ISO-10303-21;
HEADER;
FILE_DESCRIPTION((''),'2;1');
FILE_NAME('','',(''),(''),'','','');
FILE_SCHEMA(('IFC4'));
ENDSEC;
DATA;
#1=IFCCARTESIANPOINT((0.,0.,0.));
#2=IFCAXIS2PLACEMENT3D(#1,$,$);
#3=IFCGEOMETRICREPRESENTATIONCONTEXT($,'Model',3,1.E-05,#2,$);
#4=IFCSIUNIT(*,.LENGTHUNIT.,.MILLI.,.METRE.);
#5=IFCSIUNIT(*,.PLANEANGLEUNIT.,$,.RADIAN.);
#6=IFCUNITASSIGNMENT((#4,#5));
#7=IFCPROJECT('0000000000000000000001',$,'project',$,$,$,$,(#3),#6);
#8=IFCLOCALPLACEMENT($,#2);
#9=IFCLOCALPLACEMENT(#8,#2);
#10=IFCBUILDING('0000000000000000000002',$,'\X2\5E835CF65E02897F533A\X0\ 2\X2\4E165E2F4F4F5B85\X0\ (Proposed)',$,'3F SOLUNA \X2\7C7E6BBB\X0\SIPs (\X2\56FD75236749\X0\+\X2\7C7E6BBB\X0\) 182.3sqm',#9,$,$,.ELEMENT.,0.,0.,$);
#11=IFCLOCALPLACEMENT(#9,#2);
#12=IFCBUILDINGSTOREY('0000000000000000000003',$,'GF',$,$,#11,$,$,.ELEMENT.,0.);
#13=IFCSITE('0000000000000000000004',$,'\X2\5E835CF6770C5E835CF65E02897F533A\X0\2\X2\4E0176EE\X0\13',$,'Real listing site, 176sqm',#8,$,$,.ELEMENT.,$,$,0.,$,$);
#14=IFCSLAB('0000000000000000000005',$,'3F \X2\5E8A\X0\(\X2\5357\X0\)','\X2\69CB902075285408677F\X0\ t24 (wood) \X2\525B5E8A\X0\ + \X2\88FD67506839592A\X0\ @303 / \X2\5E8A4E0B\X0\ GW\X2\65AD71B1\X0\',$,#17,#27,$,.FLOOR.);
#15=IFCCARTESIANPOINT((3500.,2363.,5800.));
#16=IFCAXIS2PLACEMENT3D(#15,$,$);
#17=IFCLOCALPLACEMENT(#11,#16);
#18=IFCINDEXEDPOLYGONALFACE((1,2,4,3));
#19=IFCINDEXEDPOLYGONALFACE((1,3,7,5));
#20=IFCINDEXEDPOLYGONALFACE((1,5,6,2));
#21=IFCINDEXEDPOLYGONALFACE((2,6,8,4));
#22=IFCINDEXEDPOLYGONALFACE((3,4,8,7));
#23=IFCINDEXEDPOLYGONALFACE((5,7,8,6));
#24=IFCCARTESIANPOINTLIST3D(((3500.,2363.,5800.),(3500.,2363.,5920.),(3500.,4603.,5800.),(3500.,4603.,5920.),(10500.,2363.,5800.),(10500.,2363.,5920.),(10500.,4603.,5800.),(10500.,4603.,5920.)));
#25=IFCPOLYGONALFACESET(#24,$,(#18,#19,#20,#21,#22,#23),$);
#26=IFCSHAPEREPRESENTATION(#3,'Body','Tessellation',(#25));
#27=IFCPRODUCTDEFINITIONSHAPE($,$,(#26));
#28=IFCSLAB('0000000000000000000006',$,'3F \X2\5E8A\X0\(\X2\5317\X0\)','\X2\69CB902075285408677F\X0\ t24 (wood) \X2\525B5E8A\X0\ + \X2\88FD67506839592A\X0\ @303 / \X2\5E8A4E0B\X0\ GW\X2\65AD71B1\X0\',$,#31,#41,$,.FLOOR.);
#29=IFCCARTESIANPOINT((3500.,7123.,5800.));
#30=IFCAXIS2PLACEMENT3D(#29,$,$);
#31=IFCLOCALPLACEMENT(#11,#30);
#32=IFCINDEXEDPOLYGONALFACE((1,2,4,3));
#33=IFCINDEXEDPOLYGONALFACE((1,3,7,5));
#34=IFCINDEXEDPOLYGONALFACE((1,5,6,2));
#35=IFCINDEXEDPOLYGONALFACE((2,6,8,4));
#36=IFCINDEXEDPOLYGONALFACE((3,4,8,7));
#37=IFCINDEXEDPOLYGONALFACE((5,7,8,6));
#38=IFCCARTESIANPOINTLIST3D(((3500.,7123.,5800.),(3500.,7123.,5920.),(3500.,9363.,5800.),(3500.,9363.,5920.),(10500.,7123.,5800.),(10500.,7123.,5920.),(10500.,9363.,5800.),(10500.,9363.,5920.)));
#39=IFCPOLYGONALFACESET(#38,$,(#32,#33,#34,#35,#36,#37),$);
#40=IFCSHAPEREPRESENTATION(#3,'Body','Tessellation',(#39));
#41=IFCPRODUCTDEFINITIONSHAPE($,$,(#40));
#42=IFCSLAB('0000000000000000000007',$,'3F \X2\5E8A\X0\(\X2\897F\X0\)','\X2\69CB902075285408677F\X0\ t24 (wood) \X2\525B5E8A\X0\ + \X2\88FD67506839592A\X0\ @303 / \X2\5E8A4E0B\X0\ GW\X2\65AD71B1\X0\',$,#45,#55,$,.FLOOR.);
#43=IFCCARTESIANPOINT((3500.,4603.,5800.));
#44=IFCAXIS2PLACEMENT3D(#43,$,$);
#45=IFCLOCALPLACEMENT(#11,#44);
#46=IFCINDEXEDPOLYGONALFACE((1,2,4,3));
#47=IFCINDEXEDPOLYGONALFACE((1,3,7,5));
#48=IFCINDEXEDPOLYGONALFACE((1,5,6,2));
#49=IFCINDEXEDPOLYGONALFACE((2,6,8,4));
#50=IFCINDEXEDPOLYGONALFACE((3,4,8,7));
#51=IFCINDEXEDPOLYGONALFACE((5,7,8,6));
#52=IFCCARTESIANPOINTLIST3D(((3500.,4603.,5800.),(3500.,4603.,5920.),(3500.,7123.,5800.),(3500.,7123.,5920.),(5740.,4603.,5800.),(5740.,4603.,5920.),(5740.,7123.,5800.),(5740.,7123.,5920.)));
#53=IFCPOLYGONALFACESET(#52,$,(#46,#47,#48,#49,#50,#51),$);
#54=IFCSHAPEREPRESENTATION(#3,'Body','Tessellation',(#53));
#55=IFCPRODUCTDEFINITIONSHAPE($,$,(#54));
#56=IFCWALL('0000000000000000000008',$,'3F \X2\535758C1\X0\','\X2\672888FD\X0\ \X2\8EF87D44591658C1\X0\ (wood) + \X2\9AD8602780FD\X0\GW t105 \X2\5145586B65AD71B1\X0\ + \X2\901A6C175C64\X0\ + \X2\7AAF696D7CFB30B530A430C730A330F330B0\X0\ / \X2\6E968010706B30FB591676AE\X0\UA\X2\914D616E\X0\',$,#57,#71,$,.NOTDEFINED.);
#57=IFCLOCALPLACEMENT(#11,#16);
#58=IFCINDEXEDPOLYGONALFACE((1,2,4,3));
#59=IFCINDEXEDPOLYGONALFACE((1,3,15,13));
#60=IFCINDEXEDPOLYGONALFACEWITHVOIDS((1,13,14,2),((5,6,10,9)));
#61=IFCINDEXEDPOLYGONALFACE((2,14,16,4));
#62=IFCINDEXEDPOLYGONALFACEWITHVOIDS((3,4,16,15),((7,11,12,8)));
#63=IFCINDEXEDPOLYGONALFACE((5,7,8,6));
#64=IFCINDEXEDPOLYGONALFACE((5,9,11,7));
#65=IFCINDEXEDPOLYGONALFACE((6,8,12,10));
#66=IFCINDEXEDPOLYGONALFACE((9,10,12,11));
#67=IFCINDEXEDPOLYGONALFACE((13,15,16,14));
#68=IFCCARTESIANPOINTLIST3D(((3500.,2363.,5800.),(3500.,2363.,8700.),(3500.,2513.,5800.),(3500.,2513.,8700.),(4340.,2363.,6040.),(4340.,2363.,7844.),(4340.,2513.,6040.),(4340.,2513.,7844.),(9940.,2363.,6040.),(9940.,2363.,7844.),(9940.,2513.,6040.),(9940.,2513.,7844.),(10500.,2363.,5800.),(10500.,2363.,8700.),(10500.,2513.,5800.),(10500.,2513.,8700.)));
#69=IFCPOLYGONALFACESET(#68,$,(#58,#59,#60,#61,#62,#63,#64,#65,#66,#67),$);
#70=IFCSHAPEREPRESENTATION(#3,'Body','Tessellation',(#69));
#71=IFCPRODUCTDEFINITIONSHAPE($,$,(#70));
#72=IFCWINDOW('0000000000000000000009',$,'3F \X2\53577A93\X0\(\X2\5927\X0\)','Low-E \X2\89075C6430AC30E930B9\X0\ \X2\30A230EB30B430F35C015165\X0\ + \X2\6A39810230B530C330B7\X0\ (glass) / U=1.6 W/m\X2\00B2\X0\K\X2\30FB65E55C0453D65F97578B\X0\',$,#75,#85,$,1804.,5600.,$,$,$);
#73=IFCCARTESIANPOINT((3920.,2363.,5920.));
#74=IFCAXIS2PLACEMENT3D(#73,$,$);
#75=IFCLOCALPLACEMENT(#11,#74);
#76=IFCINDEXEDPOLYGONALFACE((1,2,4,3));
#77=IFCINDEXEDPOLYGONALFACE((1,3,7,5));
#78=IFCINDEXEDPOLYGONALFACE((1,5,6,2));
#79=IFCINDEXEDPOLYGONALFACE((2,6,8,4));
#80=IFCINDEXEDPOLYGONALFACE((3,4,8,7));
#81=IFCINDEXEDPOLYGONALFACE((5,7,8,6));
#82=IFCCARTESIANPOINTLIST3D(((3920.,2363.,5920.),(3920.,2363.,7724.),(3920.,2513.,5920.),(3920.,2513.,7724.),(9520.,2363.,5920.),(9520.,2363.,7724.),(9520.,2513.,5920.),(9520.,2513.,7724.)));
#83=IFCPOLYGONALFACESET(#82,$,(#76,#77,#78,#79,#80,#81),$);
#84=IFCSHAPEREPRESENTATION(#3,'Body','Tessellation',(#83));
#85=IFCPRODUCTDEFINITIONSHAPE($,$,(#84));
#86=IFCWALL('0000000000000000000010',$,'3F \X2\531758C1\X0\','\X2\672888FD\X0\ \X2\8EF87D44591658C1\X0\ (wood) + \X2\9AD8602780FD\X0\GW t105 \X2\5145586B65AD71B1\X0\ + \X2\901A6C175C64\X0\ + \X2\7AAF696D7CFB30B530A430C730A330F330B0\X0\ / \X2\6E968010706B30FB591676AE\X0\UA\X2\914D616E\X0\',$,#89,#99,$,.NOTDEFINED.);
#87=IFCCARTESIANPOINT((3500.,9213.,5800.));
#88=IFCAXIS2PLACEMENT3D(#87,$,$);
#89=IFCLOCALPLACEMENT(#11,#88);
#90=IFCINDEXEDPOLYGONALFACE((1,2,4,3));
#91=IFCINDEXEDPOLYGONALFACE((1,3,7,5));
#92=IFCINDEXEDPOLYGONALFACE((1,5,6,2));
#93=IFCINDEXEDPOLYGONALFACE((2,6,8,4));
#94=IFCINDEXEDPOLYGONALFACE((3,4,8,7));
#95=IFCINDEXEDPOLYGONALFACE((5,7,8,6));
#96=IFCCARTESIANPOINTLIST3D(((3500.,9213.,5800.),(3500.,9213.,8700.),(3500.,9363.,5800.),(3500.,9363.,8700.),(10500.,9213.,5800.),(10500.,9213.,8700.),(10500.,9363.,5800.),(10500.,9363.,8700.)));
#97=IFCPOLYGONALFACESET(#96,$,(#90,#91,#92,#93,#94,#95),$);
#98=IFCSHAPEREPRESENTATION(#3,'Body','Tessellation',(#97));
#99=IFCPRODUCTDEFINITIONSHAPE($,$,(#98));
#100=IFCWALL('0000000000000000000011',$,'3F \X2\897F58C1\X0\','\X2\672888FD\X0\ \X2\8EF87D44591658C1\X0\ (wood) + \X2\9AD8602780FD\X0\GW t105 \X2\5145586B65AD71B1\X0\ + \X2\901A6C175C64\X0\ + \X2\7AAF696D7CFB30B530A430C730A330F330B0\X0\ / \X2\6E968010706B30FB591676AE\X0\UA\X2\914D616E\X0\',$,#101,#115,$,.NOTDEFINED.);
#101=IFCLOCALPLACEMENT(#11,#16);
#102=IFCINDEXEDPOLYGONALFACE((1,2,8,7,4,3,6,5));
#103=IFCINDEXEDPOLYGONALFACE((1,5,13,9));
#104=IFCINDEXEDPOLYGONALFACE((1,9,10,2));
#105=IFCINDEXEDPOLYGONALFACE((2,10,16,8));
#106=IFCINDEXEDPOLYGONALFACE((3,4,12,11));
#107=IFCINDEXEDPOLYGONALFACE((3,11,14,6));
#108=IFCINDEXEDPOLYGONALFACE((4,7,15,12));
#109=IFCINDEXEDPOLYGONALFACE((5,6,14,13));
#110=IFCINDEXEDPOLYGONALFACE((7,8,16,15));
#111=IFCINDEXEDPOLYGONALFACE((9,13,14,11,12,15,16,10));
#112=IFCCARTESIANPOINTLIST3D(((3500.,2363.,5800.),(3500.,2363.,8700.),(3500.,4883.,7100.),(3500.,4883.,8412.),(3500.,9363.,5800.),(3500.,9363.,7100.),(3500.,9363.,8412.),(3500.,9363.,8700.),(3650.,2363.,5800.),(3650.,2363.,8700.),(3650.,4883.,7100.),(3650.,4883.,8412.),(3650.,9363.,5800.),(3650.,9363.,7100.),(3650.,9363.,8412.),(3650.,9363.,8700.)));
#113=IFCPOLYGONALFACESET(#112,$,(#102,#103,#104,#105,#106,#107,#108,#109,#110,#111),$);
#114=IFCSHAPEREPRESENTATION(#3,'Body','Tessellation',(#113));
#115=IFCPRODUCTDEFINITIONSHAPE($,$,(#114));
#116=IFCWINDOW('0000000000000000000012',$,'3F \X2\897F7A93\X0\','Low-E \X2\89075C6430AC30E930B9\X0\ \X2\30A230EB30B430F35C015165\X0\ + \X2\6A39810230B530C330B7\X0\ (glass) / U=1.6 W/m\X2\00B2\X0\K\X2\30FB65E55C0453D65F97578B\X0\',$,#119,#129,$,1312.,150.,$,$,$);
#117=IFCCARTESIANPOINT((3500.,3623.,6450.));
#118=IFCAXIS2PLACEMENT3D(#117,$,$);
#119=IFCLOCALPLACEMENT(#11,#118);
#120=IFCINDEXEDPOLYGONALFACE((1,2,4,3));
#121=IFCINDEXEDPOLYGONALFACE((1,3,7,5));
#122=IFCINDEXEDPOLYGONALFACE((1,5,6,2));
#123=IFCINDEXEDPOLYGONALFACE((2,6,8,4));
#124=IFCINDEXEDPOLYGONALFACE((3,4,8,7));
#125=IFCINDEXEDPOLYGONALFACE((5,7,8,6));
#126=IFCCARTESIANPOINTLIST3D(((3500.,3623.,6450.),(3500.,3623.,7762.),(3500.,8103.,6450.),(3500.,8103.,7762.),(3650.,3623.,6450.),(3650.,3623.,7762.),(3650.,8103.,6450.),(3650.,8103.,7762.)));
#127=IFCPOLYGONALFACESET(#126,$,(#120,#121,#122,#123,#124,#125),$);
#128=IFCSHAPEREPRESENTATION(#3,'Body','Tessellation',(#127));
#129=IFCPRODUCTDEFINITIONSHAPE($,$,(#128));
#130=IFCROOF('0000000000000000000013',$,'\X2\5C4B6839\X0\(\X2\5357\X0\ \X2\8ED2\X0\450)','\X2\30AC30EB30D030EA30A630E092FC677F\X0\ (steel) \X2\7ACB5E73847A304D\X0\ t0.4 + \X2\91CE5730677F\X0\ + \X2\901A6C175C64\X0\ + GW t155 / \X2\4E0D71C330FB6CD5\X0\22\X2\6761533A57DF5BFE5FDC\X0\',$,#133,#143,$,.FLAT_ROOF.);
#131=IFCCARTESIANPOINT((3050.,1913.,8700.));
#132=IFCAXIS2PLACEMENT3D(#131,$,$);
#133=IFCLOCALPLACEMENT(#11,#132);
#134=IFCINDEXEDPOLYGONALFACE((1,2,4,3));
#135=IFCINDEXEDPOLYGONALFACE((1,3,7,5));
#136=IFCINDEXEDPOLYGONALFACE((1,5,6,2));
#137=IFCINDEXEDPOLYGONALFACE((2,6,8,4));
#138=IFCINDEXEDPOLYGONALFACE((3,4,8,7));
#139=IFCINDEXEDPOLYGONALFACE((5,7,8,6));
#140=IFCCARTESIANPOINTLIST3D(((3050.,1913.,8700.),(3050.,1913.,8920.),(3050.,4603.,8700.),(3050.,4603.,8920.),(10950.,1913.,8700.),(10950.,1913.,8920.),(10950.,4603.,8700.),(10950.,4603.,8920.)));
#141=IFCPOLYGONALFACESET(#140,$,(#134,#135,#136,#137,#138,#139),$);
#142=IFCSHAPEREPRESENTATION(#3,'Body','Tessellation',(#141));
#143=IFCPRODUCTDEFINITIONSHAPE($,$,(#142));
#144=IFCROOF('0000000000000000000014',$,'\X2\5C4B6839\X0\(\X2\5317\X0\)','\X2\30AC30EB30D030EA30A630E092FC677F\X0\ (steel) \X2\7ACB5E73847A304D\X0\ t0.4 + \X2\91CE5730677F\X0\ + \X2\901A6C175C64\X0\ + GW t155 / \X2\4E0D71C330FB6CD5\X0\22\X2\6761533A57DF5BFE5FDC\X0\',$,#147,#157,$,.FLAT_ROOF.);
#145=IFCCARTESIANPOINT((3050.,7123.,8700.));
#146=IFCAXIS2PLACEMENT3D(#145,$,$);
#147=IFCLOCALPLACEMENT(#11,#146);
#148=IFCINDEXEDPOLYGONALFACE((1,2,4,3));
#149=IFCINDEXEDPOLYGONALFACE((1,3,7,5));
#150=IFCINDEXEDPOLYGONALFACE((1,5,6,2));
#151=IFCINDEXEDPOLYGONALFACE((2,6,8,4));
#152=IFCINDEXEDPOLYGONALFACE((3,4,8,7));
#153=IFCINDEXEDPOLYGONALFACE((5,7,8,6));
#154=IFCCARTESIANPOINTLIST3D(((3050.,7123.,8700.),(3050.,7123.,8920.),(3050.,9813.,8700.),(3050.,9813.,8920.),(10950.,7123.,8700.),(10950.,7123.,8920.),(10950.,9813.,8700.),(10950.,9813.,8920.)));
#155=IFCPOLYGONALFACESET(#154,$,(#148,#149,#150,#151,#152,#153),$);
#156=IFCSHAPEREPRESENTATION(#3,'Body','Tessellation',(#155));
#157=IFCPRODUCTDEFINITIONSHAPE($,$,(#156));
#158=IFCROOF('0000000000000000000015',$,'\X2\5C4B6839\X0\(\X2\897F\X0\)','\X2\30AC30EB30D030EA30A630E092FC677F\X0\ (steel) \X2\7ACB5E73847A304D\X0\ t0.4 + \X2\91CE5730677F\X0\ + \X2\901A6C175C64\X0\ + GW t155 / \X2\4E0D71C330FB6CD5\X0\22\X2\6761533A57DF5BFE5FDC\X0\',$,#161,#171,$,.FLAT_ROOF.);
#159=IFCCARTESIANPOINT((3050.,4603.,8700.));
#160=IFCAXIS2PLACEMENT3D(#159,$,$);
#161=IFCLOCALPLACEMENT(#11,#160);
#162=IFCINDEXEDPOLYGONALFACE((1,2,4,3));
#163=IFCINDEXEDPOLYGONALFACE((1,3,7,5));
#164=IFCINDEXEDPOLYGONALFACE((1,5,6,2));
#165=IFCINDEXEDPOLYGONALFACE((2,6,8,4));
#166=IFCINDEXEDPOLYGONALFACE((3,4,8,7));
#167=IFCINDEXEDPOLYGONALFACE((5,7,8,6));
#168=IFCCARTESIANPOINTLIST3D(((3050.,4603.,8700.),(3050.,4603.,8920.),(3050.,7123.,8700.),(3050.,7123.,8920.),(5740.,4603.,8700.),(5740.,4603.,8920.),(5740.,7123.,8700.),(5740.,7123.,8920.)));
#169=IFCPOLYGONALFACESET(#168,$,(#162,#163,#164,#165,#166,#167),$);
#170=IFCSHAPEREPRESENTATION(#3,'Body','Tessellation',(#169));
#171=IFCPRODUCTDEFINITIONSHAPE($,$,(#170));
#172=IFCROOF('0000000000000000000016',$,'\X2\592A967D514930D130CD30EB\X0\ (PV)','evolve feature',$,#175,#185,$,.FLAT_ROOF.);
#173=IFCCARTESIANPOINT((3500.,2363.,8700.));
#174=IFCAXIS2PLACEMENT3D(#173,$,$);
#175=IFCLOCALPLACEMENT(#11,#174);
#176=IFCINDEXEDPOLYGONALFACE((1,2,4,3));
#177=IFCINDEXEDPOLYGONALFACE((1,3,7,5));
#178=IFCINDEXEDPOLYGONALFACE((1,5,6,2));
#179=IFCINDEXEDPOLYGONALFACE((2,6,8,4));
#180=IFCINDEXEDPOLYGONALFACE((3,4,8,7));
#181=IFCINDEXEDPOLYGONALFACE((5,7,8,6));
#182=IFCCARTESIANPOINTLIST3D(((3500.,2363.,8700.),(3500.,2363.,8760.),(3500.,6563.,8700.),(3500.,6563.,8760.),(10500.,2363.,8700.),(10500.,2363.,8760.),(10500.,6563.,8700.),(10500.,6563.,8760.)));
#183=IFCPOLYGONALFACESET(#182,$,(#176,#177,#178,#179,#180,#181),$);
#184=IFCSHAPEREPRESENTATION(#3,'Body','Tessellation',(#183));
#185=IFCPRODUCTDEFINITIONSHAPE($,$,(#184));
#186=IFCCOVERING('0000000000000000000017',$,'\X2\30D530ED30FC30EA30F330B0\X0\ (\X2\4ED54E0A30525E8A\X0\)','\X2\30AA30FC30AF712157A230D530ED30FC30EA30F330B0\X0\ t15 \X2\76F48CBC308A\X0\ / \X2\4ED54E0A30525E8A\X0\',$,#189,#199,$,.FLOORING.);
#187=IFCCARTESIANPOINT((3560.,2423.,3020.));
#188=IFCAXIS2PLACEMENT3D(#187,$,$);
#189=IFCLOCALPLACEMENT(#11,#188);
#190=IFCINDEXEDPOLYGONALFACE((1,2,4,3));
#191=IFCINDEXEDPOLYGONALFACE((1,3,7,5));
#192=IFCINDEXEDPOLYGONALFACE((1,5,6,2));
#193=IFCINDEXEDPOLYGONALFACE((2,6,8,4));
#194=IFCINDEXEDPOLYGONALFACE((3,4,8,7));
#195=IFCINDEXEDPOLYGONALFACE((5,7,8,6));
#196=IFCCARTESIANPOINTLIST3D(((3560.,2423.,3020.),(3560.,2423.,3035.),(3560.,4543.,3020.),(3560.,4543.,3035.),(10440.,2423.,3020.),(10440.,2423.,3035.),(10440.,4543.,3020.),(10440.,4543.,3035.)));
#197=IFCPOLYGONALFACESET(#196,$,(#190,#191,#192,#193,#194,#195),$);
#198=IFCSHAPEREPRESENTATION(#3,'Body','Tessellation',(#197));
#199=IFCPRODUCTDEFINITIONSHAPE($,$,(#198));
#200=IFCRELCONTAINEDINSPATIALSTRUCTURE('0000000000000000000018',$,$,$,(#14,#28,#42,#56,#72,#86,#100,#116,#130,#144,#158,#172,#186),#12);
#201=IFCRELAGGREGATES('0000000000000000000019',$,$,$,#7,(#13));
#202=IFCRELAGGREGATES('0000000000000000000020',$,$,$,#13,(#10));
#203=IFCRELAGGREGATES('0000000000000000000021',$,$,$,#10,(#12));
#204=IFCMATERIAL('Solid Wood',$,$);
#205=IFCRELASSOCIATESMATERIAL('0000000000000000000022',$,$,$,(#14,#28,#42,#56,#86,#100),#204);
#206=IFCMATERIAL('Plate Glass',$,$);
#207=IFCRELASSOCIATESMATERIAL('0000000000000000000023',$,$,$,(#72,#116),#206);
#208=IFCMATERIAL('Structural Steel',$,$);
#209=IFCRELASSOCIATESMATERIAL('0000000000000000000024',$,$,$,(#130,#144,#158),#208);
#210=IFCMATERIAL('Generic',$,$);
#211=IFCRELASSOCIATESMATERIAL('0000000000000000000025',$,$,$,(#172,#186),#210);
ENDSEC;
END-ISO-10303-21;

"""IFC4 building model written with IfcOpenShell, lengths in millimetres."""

from ifc_helpers import new_model, si_unit, frame, frame_2d, origin, place, context, project, spatial, rectangle, extrude, material, element, fill, save


model = new_model("IFC4")

# Units and contexts
model_context = context("Model", 3, precision=1e-05, world=origin())
ifc_project = project(units=[si_unit("LENGTHUNIT", "METRE", prefix="MILLI"), si_unit("PLANEANGLEUNIT", "RADIAN")], contexts=[model_context])

# Site, building, storey
site_placement = place(None, origin())
site = spatial("IfcSite", under=ifc_project, at=site_placement, Name="広島県広島市西区2丁目13", ObjectType="Real listing site, 176sqm", CompositionType="ELEMENT", RefElevation=0.0)
building_placement = place(site_placement, origin())
building = spatial("IfcBuilding", under=site, at=building_placement, Name="広島市西区 2世帯住宅 (Proposed)", ObjectType="3F SOLUNA 籾殻SIPs (国産杉+籾殻) 182.3sqm", CompositionType="ELEMENT", ElevationOfRefHeight=0.0, ElevationOfTerrain=0.0)
storey_placement = place(building_placement, origin())
storey = spatial("IfcBuildingStorey", under=building, at=storey_placement, Name="GF", CompositionType="ELEMENT", Elevation=0.0)

# Slabs
ifc_material_1 = material(Name="Solid Wood")
slab_1_placement = place(storey_placement, frame((3500.0, 2363.0, 5800.0)))
element("IfcSlab", 1, at=slab_1_placement, inside=storey, material=ifc_material_1, Name="3F 床(南)", Description="構造用合板 t24 (wood) 剛床 + 製材根太 @303 / 床下 GW断熱", PredefinedType="FLOOR", context=model_context, shape_type="SweptSolid", body=[
    extrude(rectangle(XDim=7000.0, YDim=2240.0, at=frame_2d((3500.0, 1120.0))), frame((3500.0, 2363.0, 5800.0)), (0.0, 0.0, 1.0), 120.0),
])
slab_2_placement = place(storey_placement, frame((3500.0, 7123.0, 5800.0)))
element("IfcSlab", 2, at=slab_2_placement, inside=storey, material=ifc_material_1, Name="3F 床(北)", Description="構造用合板 t24 (wood) 剛床 + 製材根太 @303 / 床下 GW断熱", PredefinedType="FLOOR", context=model_context, shape_type="SweptSolid", body=[
    extrude(rectangle(XDim=7000.0, YDim=2240.0, at=frame_2d((3500.0, 1120.0))), frame((3500.0, 7123.0, 5800.0)), (0.0, 0.0, 1.0), 120.0),
])
slab_3_placement = place(storey_placement, frame((3500.0, 4603.0, 5800.0)))
element("IfcSlab", 3, at=slab_3_placement, inside=storey, material=ifc_material_1, Name="3F 床(西)", Description="構造用合板 t24 (wood) 剛床 + 製材根太 @303 / 床下 GW断熱", PredefinedType="FLOOR", context=model_context, shape_type="SweptSolid", body=[
    extrude(rectangle(XDim=2240.0, YDim=2520.0, at=frame_2d((1120.0, 1260.0))), frame((3500.0, 4603.0, 5800.0)), (0.0, 0.0, 1.0), 120.0),
])

# Wall, opening, window
wall_1_placement = place(storey_placement, frame((3500.0, 2363.0, 5800.0)))
wall_1 = element("IfcWall", 4, at=wall_1_placement, inside=storey, material=ifc_material_1, Name="3F 南壁", Description="木製 軸組外壁 (wood) + 高性能GW t105 充填断熱 + 通気層 + 窯業系サイディング / 準耐火・外皮UA配慮", PredefinedType="NOTDEFINED", context=model_context, shape_type="SweptSolid", body=[
    extrude(rectangle(XDim=7000.0, YDim=150.0, at=frame_2d((3500.0, 75.0))), frame((3500.0, 2363.0, 5800.0)), (0.0, 0.0, 1.0), 2900.0),
])
opening_1_placement = place(storey_placement, frame((3920.0, 2363.0, 5920.0)))
opening_1 = element("IfcOpeningElement", 5, at=opening_1_placement, cuts=wall_1, PredefinedType="NOTDEFINED", context=model_context, shape_type="SweptSolid", body=[
    extrude(rectangle(XDim=5600.0, YDim=150.0, at=frame_2d((2800.0, 75.0))), frame((3920.0, 2363.0, 5920.0)), (0.0, 0.0, 1.0), 1804.0),
])
ifc_material_2 = material(Name="Plate Glass")
window_1_placement = place(storey_placement, frame((3920.0, 2363.0, 5920.0)))
window_1 = element("IfcWindow", 6, at=window_1_placement, inside=storey, material=ifc_material_2, Name="3F 南窓(大)", Description="Low-E 複層ガラス アルゴン封入 + 樹脂サッシ (glass) / U=1.6 W/m²K・日射取得型", OverallHeight=1804.0, OverallWidth=5600.0, context=model_context, shape_type="SweptSolid", body=[
    extrude(rectangle(XDim=5600.0, YDim=150.0, at=frame_2d((2800.0, 75.0))), frame((3920.0, 2363.0, 5920.0)), (0.0, 0.0, 1.0), 1804.0),
])
fill(opening_1, window_1)

# Wall
wall_2_placement = place(storey_placement, frame((3500.0, 9213.0, 5800.0)))
element("IfcWall", 7, at=wall_2_placement, inside=storey, material=ifc_material_1, Name="3F 北壁", Description="木製 軸組外壁 (wood) + 高性能GW t105 充填断熱 + 通気層 + 窯業系サイディング / 準耐火・外皮UA配慮", PredefinedType="NOTDEFINED", context=model_context, shape_type="SweptSolid", body=[
    extrude(rectangle(XDim=7000.0, YDim=150.0, at=frame_2d((3500.0, 75.0))), frame((3500.0, 9213.0, 5800.0)), (0.0, 0.0, 1.0), 2900.0),
])

# Wall, opening, window
wall_3_placement = place(storey_placement, frame((3500.0, 2363.0, 5800.0)))
wall_3 = element("IfcWall", 8, at=wall_3_placement, inside=storey, material=ifc_material_1, Name="3F 西壁", Description="木製 軸組外壁 (wood) + 高性能GW t105 充填断熱 + 通気層 + 窯業系サイディング / 準耐火・外皮UA配慮", PredefinedType="NOTDEFINED", context=model_context, shape_type="SweptSolid", body=[
    extrude(rectangle(XDim=150.0, YDim=7000.0, at=frame_2d((75.0, 3500.0))), frame((3500.0, 2363.0, 5800.0)), (0.0, 0.0, 1.0), 2900.0),
])
opening_2_placement = place(storey_placement, frame((3500.0, 3623.0, 6450.0)))
opening_2 = element("IfcOpeningElement", 9, at=opening_2_placement, cuts=wall_3, PredefinedType="NOTDEFINED", context=model_context, shape_type="SweptSolid", body=[
    extrude(rectangle(XDim=150.0, YDim=4480.0, at=frame_2d((75.0, 2240.0))), frame((3500.0, 3623.0, 6450.0)), (0.0, 0.0, 1.0), 1312.0),
])
window_2_placement = place(storey_placement, frame((3500.0, 3623.0, 6450.0)))
window_2 = element("IfcWindow", 10, at=window_2_placement, inside=storey, material=ifc_material_2, Name="3F 西窓", Description="Low-E 複層ガラス アルゴン封入 + 樹脂サッシ (glass) / U=1.6 W/m²K・日射取得型", OverallHeight=1312.0, OverallWidth=150.0, context=model_context, shape_type="SweptSolid", body=[
    extrude(rectangle(XDim=150.0, YDim=4480.0, at=frame_2d((75.0, 2240.0))), frame((3500.0, 3623.0, 6450.0)), (0.0, 0.0, 1.0), 1312.0),
])
fill(opening_2, window_2)

# Roofs
ifc_material_3 = material(Name="Structural Steel")
roof_1_placement = place(storey_placement, frame((3050.0, 1913.0, 8700.0)))
element("IfcRoof", 11, at=roof_1_placement, inside=storey, material=ifc_material_3, Name="屋根(南 軒450)", Description="ガルバリウム鋼板 (steel) 立平葺き t0.4 + 野地板 + 通気層 + GW t155 / 不燃・法22条区域対応", PredefinedType="FLAT_ROOF", context=model_context, shape_type="SweptSolid", body=[
    extrude(rectangle(XDim=7900.0, YDim=2690.0, at=frame_2d((3950.0, 1345.0))), frame((3050.0, 1913.0, 8700.0)), (0.0, 0.0, 1.0), 220.0),
])
roof_2_placement = place(storey_placement, frame((3050.0, 7123.0, 8700.0)))
element("IfcRoof", 12, at=roof_2_placement, inside=storey, material=ifc_material_3, Name="屋根(北)", Description="ガルバリウム鋼板 (steel) 立平葺き t0.4 + 野地板 + 通気層 + GW t155 / 不燃・法22条区域対応", PredefinedType="FLAT_ROOF", context=model_context, shape_type="SweptSolid", body=[
    extrude(rectangle(XDim=7900.0, YDim=2690.0, at=frame_2d((3950.0, 1345.0))), frame((3050.0, 7123.0, 8700.0)), (0.0, 0.0, 1.0), 220.0),
])
roof_3_placement = place(storey_placement, frame((3050.0, 4603.0, 8700.0)))
element("IfcRoof", 13, at=roof_3_placement, inside=storey, material=ifc_material_3, Name="屋根(西)", Description="ガルバリウム鋼板 (steel) 立平葺き t0.4 + 野地板 + 通気層 + GW t155 / 不燃・法22条区域対応", PredefinedType="FLAT_ROOF", context=model_context, shape_type="SweptSolid", body=[
    extrude(rectangle(XDim=2690.0, YDim=2520.0, at=frame_2d((1345.0, 1260.0))), frame((3050.0, 4603.0, 8700.0)), (0.0, 0.0, 1.0), 220.0),
])
ifc_material_4 = material(Name="Generic")
roof_4_placement = place(storey_placement, frame((3500.0, 2363.0, 8700.0)))
element("IfcRoof", 14, at=roof_4_placement, inside=storey, material=ifc_material_4, Name="太陽光パネル (PV)", Description="evolve feature", PredefinedType="FLAT_ROOF", context=model_context, shape_type="SweptSolid", body=[
    extrude(rectangle(XDim=7000.0, YDim=4200.0, at=frame_2d((3500.0, 2100.0))), frame((3500.0, 2363.0, 8700.0)), (0.0, 0.0, 1.0), 60.0),
])

# Covering
covering_1_placement = place(storey_placement, frame((3560.0, 2423.0, 3020.0)))
element("IfcCovering", 15, at=covering_1_placement, inside=storey, material=ifc_material_4, Name="フローリング (仕上げ床)", Description="オーク無垢フローリング t15 直貼り / 仕上げ床", PredefinedType="FLOORING", context=model_context, shape_type="SweptSolid", body=[
    extrude(rectangle(XDim=6880.0, YDim=2120.0, at=frame_2d((3440.0, 1060.0))), frame((3560.0, 2423.0, 3020.0)), (0.0, 0.0, 1.0), 15.0),
])

save(model, "model.ifc")
